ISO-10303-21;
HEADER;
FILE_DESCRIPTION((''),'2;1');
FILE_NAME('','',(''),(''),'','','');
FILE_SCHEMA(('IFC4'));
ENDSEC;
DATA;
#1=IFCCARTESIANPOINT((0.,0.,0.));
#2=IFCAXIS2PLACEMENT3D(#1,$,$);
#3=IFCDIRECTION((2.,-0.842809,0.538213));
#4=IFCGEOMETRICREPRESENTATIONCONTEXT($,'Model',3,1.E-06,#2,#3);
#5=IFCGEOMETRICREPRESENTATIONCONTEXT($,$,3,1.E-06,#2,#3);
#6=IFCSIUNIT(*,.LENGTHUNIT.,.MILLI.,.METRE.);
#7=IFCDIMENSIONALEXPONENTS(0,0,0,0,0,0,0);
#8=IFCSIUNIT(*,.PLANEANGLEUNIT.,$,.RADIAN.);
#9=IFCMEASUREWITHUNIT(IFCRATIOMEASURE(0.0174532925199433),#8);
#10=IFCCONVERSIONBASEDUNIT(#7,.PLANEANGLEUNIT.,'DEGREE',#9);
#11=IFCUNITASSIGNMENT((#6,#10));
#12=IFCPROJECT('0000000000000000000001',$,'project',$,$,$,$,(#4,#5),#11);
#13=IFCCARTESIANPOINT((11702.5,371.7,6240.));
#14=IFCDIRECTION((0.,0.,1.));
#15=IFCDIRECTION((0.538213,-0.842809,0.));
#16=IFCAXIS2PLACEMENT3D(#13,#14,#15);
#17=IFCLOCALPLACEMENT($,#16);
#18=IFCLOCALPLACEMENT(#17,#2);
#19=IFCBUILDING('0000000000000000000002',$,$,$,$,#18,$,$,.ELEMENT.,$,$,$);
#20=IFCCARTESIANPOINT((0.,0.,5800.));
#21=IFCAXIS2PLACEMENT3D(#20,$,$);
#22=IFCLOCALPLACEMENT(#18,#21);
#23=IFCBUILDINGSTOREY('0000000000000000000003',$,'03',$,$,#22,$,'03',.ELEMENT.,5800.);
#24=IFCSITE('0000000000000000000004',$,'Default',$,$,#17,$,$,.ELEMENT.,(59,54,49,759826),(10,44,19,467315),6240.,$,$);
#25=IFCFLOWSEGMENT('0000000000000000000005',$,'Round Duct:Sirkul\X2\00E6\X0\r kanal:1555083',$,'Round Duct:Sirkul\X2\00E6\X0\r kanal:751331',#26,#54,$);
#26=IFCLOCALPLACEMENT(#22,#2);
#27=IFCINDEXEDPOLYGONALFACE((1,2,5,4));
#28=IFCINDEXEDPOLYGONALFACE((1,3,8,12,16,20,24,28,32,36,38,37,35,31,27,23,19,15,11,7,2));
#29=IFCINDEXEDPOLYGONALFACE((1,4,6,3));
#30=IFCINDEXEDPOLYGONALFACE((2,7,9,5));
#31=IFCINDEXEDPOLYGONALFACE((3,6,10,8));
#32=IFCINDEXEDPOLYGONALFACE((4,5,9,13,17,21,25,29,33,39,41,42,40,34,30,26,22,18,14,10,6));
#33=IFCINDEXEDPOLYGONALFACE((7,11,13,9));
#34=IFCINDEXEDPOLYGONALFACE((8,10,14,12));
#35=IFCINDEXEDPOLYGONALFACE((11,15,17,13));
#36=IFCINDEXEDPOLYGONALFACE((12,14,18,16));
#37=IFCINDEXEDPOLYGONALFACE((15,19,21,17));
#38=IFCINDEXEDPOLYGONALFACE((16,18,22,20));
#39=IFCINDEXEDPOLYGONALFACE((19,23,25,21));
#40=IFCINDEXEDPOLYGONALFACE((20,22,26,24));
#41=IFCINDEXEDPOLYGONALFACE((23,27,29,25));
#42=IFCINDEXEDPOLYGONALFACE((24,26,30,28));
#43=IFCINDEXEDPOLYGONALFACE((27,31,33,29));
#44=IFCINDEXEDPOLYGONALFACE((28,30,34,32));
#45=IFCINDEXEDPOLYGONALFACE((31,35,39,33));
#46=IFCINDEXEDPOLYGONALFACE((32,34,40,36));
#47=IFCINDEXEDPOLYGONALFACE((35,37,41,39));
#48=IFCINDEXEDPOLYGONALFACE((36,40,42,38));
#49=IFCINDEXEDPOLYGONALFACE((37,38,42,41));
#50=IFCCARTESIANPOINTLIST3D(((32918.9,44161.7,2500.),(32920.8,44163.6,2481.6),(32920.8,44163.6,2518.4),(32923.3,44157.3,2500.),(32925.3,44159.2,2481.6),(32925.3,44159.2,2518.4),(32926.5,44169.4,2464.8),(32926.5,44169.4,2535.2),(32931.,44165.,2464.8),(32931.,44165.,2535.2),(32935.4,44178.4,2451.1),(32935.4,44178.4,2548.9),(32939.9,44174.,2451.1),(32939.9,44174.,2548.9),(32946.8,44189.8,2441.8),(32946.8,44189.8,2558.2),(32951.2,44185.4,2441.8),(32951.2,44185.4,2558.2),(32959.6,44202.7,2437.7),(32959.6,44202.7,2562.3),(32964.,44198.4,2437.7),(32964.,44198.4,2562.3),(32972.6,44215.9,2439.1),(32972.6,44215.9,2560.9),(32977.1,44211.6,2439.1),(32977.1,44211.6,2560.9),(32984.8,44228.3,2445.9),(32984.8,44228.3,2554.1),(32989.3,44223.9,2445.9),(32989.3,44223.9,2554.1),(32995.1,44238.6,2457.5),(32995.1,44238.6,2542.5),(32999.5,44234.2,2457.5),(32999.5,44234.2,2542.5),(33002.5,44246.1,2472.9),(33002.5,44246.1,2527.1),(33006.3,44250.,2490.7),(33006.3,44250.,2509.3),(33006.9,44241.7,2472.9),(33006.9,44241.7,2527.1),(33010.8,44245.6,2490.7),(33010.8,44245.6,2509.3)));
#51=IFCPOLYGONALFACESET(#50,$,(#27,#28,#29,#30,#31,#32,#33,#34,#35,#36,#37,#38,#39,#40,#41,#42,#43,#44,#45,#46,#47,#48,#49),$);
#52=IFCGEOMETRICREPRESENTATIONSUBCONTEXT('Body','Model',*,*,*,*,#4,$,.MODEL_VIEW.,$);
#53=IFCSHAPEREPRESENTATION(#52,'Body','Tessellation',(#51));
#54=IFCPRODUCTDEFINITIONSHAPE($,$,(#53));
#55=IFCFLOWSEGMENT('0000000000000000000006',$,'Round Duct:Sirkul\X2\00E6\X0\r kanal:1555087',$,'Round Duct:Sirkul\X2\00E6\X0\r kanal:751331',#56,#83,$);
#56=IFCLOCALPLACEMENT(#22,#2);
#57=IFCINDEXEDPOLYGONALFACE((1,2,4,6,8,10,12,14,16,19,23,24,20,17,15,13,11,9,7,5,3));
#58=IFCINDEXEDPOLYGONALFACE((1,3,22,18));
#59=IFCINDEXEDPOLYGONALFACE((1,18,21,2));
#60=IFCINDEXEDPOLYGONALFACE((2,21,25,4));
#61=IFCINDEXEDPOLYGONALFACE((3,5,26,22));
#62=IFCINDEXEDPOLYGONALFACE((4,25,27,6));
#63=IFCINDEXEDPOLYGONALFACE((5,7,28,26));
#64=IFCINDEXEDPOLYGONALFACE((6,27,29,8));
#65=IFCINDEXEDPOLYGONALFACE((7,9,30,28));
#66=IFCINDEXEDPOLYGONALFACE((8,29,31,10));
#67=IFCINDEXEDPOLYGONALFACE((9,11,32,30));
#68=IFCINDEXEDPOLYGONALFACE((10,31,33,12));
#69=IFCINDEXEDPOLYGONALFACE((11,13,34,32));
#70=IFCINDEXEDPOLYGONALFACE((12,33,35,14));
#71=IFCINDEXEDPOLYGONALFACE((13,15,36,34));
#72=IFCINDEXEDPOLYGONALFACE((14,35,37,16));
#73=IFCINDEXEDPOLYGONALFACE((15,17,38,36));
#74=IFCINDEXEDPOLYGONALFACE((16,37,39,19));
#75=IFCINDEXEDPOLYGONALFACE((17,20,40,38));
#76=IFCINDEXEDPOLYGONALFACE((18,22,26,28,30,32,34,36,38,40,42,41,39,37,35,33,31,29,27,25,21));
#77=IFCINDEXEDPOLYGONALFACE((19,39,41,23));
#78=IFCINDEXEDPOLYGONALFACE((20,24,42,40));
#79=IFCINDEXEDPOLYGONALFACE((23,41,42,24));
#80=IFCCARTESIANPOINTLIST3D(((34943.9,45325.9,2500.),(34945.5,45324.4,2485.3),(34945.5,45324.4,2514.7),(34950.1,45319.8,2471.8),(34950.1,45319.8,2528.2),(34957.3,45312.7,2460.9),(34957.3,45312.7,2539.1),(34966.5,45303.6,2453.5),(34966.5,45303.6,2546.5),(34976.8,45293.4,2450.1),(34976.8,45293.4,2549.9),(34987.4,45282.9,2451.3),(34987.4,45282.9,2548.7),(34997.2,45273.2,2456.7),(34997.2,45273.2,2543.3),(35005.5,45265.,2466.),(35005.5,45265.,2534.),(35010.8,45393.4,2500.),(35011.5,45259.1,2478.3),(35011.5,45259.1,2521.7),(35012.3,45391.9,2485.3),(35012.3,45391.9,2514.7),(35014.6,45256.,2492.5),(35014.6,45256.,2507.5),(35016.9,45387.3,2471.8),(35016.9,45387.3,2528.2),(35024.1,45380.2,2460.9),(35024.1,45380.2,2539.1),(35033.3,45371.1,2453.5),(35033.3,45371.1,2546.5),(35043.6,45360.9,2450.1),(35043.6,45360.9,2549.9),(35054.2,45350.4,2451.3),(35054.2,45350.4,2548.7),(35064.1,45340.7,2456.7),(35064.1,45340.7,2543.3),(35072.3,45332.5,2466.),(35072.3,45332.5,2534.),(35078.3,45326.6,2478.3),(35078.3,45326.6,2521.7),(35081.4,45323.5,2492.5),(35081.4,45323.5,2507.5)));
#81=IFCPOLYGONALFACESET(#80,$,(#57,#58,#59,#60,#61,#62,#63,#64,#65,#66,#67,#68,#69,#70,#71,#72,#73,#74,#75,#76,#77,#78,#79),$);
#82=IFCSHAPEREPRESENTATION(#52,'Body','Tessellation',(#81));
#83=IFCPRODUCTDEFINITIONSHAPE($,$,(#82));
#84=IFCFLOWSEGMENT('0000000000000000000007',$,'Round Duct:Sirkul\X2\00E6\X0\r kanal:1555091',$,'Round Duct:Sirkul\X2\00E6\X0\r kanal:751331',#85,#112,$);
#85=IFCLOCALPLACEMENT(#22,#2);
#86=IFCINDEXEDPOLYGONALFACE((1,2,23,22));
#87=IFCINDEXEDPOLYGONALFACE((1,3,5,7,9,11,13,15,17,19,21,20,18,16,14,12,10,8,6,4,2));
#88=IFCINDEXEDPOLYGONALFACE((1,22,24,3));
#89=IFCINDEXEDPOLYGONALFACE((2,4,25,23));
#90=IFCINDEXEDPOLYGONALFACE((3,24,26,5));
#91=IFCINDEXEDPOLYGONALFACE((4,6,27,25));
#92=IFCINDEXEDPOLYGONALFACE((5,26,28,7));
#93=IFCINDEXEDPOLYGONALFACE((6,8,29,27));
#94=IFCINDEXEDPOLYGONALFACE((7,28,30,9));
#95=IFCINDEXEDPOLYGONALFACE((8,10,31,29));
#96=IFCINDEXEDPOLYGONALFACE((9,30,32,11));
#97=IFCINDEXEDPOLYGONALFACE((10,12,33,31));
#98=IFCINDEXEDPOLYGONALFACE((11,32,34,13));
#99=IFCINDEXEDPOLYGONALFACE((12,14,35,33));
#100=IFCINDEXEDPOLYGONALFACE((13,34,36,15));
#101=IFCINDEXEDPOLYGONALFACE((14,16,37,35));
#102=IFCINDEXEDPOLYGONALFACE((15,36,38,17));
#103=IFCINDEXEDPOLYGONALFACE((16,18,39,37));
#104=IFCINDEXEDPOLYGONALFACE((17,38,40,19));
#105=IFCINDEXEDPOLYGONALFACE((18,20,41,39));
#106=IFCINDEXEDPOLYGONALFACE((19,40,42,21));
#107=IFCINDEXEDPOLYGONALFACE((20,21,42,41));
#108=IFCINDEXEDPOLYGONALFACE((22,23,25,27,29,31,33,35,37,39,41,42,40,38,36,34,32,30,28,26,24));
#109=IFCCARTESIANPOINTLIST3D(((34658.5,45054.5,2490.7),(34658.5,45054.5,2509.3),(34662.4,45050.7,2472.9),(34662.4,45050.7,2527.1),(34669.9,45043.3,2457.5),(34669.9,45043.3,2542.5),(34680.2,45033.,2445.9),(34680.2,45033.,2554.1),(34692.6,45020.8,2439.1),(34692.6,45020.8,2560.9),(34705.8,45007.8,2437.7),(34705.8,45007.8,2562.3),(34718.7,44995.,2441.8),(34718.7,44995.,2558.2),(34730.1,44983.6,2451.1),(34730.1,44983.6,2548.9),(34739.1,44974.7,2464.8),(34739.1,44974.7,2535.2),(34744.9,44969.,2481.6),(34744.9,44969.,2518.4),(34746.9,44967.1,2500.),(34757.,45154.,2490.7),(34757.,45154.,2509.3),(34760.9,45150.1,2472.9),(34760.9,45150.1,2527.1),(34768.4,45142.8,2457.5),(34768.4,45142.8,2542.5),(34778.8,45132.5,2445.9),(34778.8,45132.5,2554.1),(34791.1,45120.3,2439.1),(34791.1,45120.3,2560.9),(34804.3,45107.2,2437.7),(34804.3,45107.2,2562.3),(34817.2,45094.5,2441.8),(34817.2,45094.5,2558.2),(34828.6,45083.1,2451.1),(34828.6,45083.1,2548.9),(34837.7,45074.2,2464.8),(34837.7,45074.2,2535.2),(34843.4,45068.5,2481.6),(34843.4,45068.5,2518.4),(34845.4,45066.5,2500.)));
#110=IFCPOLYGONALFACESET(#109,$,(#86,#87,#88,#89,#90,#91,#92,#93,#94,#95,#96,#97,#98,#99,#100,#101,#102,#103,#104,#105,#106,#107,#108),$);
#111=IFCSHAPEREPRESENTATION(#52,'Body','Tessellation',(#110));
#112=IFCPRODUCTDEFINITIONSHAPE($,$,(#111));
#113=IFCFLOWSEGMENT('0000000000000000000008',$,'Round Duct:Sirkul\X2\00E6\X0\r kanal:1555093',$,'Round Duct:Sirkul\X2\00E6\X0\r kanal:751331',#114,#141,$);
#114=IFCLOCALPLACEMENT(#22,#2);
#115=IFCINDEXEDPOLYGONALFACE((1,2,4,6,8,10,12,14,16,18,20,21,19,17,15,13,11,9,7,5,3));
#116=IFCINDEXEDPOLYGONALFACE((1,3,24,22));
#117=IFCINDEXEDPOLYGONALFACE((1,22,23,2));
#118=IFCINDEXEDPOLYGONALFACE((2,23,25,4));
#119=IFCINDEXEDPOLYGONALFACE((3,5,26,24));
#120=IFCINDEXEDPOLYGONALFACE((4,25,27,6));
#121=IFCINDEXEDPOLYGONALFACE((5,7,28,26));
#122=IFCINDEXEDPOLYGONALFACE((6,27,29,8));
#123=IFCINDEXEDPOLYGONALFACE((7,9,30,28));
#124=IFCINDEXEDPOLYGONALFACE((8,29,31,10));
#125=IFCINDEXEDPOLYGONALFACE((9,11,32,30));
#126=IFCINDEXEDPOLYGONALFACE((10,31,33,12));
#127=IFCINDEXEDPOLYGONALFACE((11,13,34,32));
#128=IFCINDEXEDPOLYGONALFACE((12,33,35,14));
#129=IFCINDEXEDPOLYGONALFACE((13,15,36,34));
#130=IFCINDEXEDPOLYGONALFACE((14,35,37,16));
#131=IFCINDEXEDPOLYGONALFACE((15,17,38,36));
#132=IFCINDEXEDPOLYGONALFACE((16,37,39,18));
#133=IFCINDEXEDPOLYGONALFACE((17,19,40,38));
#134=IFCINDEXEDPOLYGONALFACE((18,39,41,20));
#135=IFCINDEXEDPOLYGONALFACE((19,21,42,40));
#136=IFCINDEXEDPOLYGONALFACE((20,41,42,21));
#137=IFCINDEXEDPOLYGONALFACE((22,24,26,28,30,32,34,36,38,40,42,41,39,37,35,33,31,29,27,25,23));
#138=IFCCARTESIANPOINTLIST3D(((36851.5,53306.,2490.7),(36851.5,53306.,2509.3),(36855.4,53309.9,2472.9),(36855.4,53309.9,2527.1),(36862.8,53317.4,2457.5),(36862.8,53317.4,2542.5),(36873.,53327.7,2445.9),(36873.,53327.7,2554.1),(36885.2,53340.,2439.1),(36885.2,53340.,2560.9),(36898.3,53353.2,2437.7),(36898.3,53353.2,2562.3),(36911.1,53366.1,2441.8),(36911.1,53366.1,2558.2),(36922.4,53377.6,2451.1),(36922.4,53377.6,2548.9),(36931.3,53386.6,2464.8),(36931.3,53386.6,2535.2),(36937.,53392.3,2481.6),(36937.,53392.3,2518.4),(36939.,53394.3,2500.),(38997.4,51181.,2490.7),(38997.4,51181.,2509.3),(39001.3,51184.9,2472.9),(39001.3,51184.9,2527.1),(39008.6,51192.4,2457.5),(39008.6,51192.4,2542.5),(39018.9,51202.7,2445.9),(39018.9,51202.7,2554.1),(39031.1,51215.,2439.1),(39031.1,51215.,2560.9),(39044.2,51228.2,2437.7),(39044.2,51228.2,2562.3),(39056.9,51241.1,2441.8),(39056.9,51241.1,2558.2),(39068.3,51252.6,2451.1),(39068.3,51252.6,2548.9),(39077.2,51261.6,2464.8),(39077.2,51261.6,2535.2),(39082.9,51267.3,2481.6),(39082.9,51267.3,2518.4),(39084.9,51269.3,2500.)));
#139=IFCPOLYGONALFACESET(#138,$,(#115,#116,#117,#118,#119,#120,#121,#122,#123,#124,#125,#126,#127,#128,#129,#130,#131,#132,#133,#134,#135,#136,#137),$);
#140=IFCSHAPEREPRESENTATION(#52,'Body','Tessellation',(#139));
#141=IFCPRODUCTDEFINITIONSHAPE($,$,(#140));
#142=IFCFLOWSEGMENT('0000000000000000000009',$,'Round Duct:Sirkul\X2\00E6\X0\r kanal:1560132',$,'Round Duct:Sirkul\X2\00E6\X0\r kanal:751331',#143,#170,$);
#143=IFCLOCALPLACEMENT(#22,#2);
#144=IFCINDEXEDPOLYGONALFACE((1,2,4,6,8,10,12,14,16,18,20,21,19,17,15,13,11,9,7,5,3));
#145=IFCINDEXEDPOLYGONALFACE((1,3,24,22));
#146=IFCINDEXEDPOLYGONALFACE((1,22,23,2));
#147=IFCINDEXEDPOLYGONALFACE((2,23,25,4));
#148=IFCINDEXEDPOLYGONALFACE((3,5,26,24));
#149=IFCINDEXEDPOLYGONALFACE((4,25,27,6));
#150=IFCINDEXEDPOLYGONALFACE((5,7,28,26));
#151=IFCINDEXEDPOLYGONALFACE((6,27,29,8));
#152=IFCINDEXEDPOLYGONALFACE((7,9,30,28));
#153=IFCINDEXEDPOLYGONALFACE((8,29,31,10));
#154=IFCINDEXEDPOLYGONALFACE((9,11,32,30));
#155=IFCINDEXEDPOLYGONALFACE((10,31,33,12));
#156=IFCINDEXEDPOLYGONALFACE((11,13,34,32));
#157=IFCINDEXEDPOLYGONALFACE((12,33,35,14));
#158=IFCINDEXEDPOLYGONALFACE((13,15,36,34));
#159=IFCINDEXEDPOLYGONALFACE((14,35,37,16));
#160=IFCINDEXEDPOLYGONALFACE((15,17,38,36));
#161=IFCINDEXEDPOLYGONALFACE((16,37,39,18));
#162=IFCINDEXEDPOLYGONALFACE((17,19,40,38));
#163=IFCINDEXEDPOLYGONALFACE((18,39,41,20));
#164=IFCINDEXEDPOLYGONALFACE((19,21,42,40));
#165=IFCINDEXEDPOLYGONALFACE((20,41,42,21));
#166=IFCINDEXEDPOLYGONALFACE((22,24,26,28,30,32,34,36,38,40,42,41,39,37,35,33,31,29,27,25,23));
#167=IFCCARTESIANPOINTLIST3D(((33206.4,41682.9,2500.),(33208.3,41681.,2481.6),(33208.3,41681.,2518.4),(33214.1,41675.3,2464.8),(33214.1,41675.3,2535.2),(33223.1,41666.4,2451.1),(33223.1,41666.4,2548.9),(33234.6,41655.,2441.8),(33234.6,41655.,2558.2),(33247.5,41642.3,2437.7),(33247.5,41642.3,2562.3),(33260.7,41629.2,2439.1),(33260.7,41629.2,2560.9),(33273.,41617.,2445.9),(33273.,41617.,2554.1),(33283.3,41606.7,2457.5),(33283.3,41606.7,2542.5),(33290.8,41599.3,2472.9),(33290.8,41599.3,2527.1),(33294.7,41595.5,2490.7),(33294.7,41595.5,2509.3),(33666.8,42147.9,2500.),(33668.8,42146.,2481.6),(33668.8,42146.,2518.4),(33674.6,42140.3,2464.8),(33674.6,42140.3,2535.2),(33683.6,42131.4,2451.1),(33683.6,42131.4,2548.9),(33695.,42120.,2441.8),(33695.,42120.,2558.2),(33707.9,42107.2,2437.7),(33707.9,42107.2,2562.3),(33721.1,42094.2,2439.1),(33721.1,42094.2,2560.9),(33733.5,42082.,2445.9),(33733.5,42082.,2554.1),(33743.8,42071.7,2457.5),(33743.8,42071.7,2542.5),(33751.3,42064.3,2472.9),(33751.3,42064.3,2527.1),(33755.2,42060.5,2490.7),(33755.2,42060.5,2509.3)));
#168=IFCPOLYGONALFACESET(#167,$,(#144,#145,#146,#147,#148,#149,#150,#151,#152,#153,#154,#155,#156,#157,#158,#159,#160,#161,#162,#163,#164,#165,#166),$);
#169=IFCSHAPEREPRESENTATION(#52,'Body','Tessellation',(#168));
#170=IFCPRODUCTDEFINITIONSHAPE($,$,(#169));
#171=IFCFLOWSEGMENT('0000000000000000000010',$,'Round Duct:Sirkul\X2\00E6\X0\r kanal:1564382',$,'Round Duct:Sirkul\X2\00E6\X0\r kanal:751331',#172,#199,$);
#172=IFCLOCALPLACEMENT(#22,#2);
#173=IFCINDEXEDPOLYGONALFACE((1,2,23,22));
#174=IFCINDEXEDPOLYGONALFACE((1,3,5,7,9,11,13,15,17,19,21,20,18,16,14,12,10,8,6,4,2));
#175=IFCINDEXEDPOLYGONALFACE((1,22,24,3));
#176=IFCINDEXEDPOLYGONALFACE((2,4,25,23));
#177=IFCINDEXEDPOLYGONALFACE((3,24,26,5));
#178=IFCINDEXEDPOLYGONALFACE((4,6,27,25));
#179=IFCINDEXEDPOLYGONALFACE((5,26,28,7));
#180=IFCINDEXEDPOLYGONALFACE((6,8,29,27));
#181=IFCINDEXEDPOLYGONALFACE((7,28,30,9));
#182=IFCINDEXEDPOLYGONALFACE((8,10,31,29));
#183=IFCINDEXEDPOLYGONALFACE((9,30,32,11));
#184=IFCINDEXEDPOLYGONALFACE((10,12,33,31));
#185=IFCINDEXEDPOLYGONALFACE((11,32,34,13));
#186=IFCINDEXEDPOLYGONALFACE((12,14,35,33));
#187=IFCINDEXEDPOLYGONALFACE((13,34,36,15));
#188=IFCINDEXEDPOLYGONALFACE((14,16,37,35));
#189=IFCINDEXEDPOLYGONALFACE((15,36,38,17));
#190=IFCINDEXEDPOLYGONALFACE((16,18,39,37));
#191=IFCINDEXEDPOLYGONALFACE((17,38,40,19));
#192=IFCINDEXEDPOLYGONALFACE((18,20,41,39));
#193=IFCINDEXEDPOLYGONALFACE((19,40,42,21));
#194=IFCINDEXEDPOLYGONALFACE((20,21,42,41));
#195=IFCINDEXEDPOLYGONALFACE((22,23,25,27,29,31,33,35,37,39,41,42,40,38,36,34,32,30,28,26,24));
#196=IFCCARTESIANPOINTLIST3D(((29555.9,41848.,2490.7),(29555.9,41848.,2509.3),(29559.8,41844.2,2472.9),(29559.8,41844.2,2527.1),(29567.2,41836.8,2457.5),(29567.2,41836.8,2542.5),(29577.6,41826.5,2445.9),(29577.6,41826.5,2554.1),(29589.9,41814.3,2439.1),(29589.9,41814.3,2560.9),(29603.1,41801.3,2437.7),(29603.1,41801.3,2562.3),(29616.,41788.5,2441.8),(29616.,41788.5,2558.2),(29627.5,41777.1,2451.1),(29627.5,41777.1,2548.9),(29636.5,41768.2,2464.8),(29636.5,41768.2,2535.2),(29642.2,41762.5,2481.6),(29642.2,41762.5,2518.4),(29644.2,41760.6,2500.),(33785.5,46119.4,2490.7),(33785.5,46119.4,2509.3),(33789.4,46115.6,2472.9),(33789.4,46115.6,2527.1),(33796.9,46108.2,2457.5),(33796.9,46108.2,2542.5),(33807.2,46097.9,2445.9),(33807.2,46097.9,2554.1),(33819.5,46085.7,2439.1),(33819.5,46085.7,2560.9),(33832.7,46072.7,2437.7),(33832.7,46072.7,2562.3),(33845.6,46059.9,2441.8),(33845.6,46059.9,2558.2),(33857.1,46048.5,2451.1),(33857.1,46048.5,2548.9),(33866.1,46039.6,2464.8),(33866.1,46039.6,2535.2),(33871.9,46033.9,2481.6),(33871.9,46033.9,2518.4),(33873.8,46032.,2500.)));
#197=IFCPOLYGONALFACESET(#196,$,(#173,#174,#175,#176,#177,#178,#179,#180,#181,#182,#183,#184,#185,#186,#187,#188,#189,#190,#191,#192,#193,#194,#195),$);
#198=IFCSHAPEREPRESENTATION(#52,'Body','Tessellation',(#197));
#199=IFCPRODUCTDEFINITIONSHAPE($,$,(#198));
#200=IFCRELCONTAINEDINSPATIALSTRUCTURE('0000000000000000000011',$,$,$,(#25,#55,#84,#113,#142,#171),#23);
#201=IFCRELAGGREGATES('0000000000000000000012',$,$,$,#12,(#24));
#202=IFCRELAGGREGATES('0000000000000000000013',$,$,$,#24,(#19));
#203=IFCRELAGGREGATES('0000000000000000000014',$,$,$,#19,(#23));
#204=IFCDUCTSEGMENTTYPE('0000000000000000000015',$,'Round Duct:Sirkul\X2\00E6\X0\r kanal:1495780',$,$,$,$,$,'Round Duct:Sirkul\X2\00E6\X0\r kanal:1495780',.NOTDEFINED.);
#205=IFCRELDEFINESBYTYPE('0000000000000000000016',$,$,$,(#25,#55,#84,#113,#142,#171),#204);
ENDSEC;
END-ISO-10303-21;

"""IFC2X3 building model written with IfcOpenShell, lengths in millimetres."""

from ifc_helpers import new_model, entity, si_unit, converted_unit, direction, frame, frame_2d, origin, origin_2d_with_axis, place, context, subcontext, project, spatial, circle, extrude, type_object, element, save


model = new_model("IFC2X3")

# Units and contexts
model_context = context("Model", 3, precision=1e-06, world=origin(), true_north=direction((2.0, -0.842809, 0.538213)))
context_of_model = context(None, 3, precision=1e-06, world=origin(), true_north=direction((2.0, -0.842809, 0.538213)))
body_context = subcontext(model_context, "Body", "Model", "MODEL_VIEW")
ifc_project = project(units=[si_unit("LENGTHUNIT", "METRE", prefix="MILLI"), converted_unit("PLANEANGLEUNIT", "DEGREE", entity("IfcRatioMeasure", 0.0174532925199433), si_unit("PLANEANGLEUNIT", "RADIAN"), dimensions=[0, 0, 0, 0, 0, 0, 0])], contexts=[model_context, context_of_model])

# Site, building, storey
site_placement = place(None, frame((11702.5, 371.7, 6240.0), z_axis=(0.0, 0.0, 1.0), x_axis=(0.538213, -0.842809, 0.0)))
site = spatial("IfcSite", under=ifc_project, at=site_placement, Name="Default", CompositionType="ELEMENT", RefLatitude=(59, 54, 49, 759826), RefLongitude=(10, 44, 19, 467315), RefElevation=6240.0)
building_placement = place(site_placement, origin())
building = spatial("IfcBuilding", under=site, at=building_placement, CompositionType="ELEMENT")
storey_placement = place(building_placement, frame((0.0, 0.0, 5800.0)))
storey = spatial("IfcBuildingStorey", under=building, at=storey_placement, Name="03", LongName="03", CompositionType="ELEMENT", Elevation=5800.0)

# Flow segments
duct_segment_type = type_object("IfcDuctSegmentType", Name="Round Duct:Sirkulær kanal:1495780", ElementType="Round Duct:Sirkulær kanal:1495780", PredefinedType="NOTDEFINED")
flow_segment_1_placement = place(storey_placement, origin())
element("IfcFlowSegment", 1, at=flow_segment_1_placement, inside=storey, type_object=duct_segment_type, Name="Round Duct:Sirkulær kanal:1555083", ObjectType="Round Duct:Sirkulær kanal:751331", context=body_context, shape_type="SweptSolid", body=[
    extrude(circle(Radius=62.5, at=frame_2d((0.0, 0.0), x_axis=(1.0, 0.0))), frame((32967.3, 44201.7, 2500.0), z_axis=(-0.710554, 0.703643, 0.0), x_axis=(-0.703643, -0.710554, 0.0)), (0.0, 0.0, 1.0), 6.2),
])
flow_segment_2_placement = place(storey_placement, origin())
element("IfcFlowSegment", 2, at=flow_segment_2_placement, inside=storey, type_object=duct_segment_type, Name="Round Duct:Sirkulær kanal:1555087", ObjectType="Round Duct:Sirkulær kanal:751331", context=body_context, shape_type="SweptSolid", body=[
    extrude(circle(Radius=50.0, at=origin_2d_with_axis()), frame((34979.4, 45290.8, 2500.0), z_axis=(0.703643, 0.710554, 0.0), x_axis=(-0.710554, 0.703643, 0.0)), (0.0, 0.0, 1.0), 95.0),
])
flow_segment_3_placement = place(storey_placement, origin())
element("IfcFlowSegment", 3, at=flow_segment_3_placement, inside=storey, type_object=duct_segment_type, Name="Round Duct:Sirkulær kanal:1555091", ObjectType="Round Duct:Sirkulær kanal:751331", context=body_context, shape_type="SweptSolid", body=[
    extrude(circle(Radius=62.5, at=frame_2d((0.0, 0.0), x_axis=(1.0, 0.0))), frame((34702.4, 45011.0, 2500.0), z_axis=(0.703643, 0.710554, 0.0), x_axis=(0.710554, -0.703643, 0.0)), (0.0, 0.0, 1.0), 140.0),
])
flow_segment_4_placement = place(storey_placement, origin())
element("IfcFlowSegment", 4, at=flow_segment_4_placement, inside=storey, type_object=duct_segment_type, Name="Round Duct:Sirkulær kanal:1555093", ObjectType="Round Duct:Sirkulær kanal:751331", context=body_context, shape_type="SweptSolid", body=[
    extrude(circle(Radius=62.5, at=frame_2d((0.0, 0.0), x_axis=(1.0, 0.0))), frame((36895.0, 53349.9, 2500.0), z_axis=(0.710554, -0.703643, 0.0), x_axis=(0.703643, 0.710554, 0.0)), (0.0, 0.0, 1.0), 3020.0),
])
flow_segment_5_placement = place(storey_placement, origin())
element("IfcFlowSegment", 5, at=flow_segment_5_placement, inside=storey, type_object=duct_segment_type, Name="Round Duct:Sirkulær kanal:1560132", ObjectType="Round Duct:Sirkulær kanal:751331", context=body_context, shape_type="SweptSolid", body=[
    extrude(circle(Radius=62.5, at=frame_2d((0.0, 0.0), x_axis=(1.0, 0.0))), frame((33250.8, 41639.0, 2500.0), z_axis=(0.703643, 0.710554, 0.0), x_axis=(-0.710554, 0.703643, 0.0)), (0.0, 0.0, 1.0), 654.4),
])
flow_segment_6_placement = place(storey_placement, origin())
element("IfcFlowSegment", 6, at=flow_segment_6_placement, inside=storey, type_object=duct_segment_type, Name="Round Duct:Sirkulær kanal:1564382", ObjectType="Round Duct:Sirkulær kanal:751331", context=body_context, shape_type="SweptSolid", body=[
    extrude(circle(Radius=62.5, at=origin_2d_with_axis()), frame((29599.8, 41804.5, 2500.0), z_axis=(0.703625, 0.710572, 0.0), x_axis=(0.710572, -0.703625, 0.0)), (0.0, 0.0, 1.0), 6011.2),
])

save(model, "model.ifc")
